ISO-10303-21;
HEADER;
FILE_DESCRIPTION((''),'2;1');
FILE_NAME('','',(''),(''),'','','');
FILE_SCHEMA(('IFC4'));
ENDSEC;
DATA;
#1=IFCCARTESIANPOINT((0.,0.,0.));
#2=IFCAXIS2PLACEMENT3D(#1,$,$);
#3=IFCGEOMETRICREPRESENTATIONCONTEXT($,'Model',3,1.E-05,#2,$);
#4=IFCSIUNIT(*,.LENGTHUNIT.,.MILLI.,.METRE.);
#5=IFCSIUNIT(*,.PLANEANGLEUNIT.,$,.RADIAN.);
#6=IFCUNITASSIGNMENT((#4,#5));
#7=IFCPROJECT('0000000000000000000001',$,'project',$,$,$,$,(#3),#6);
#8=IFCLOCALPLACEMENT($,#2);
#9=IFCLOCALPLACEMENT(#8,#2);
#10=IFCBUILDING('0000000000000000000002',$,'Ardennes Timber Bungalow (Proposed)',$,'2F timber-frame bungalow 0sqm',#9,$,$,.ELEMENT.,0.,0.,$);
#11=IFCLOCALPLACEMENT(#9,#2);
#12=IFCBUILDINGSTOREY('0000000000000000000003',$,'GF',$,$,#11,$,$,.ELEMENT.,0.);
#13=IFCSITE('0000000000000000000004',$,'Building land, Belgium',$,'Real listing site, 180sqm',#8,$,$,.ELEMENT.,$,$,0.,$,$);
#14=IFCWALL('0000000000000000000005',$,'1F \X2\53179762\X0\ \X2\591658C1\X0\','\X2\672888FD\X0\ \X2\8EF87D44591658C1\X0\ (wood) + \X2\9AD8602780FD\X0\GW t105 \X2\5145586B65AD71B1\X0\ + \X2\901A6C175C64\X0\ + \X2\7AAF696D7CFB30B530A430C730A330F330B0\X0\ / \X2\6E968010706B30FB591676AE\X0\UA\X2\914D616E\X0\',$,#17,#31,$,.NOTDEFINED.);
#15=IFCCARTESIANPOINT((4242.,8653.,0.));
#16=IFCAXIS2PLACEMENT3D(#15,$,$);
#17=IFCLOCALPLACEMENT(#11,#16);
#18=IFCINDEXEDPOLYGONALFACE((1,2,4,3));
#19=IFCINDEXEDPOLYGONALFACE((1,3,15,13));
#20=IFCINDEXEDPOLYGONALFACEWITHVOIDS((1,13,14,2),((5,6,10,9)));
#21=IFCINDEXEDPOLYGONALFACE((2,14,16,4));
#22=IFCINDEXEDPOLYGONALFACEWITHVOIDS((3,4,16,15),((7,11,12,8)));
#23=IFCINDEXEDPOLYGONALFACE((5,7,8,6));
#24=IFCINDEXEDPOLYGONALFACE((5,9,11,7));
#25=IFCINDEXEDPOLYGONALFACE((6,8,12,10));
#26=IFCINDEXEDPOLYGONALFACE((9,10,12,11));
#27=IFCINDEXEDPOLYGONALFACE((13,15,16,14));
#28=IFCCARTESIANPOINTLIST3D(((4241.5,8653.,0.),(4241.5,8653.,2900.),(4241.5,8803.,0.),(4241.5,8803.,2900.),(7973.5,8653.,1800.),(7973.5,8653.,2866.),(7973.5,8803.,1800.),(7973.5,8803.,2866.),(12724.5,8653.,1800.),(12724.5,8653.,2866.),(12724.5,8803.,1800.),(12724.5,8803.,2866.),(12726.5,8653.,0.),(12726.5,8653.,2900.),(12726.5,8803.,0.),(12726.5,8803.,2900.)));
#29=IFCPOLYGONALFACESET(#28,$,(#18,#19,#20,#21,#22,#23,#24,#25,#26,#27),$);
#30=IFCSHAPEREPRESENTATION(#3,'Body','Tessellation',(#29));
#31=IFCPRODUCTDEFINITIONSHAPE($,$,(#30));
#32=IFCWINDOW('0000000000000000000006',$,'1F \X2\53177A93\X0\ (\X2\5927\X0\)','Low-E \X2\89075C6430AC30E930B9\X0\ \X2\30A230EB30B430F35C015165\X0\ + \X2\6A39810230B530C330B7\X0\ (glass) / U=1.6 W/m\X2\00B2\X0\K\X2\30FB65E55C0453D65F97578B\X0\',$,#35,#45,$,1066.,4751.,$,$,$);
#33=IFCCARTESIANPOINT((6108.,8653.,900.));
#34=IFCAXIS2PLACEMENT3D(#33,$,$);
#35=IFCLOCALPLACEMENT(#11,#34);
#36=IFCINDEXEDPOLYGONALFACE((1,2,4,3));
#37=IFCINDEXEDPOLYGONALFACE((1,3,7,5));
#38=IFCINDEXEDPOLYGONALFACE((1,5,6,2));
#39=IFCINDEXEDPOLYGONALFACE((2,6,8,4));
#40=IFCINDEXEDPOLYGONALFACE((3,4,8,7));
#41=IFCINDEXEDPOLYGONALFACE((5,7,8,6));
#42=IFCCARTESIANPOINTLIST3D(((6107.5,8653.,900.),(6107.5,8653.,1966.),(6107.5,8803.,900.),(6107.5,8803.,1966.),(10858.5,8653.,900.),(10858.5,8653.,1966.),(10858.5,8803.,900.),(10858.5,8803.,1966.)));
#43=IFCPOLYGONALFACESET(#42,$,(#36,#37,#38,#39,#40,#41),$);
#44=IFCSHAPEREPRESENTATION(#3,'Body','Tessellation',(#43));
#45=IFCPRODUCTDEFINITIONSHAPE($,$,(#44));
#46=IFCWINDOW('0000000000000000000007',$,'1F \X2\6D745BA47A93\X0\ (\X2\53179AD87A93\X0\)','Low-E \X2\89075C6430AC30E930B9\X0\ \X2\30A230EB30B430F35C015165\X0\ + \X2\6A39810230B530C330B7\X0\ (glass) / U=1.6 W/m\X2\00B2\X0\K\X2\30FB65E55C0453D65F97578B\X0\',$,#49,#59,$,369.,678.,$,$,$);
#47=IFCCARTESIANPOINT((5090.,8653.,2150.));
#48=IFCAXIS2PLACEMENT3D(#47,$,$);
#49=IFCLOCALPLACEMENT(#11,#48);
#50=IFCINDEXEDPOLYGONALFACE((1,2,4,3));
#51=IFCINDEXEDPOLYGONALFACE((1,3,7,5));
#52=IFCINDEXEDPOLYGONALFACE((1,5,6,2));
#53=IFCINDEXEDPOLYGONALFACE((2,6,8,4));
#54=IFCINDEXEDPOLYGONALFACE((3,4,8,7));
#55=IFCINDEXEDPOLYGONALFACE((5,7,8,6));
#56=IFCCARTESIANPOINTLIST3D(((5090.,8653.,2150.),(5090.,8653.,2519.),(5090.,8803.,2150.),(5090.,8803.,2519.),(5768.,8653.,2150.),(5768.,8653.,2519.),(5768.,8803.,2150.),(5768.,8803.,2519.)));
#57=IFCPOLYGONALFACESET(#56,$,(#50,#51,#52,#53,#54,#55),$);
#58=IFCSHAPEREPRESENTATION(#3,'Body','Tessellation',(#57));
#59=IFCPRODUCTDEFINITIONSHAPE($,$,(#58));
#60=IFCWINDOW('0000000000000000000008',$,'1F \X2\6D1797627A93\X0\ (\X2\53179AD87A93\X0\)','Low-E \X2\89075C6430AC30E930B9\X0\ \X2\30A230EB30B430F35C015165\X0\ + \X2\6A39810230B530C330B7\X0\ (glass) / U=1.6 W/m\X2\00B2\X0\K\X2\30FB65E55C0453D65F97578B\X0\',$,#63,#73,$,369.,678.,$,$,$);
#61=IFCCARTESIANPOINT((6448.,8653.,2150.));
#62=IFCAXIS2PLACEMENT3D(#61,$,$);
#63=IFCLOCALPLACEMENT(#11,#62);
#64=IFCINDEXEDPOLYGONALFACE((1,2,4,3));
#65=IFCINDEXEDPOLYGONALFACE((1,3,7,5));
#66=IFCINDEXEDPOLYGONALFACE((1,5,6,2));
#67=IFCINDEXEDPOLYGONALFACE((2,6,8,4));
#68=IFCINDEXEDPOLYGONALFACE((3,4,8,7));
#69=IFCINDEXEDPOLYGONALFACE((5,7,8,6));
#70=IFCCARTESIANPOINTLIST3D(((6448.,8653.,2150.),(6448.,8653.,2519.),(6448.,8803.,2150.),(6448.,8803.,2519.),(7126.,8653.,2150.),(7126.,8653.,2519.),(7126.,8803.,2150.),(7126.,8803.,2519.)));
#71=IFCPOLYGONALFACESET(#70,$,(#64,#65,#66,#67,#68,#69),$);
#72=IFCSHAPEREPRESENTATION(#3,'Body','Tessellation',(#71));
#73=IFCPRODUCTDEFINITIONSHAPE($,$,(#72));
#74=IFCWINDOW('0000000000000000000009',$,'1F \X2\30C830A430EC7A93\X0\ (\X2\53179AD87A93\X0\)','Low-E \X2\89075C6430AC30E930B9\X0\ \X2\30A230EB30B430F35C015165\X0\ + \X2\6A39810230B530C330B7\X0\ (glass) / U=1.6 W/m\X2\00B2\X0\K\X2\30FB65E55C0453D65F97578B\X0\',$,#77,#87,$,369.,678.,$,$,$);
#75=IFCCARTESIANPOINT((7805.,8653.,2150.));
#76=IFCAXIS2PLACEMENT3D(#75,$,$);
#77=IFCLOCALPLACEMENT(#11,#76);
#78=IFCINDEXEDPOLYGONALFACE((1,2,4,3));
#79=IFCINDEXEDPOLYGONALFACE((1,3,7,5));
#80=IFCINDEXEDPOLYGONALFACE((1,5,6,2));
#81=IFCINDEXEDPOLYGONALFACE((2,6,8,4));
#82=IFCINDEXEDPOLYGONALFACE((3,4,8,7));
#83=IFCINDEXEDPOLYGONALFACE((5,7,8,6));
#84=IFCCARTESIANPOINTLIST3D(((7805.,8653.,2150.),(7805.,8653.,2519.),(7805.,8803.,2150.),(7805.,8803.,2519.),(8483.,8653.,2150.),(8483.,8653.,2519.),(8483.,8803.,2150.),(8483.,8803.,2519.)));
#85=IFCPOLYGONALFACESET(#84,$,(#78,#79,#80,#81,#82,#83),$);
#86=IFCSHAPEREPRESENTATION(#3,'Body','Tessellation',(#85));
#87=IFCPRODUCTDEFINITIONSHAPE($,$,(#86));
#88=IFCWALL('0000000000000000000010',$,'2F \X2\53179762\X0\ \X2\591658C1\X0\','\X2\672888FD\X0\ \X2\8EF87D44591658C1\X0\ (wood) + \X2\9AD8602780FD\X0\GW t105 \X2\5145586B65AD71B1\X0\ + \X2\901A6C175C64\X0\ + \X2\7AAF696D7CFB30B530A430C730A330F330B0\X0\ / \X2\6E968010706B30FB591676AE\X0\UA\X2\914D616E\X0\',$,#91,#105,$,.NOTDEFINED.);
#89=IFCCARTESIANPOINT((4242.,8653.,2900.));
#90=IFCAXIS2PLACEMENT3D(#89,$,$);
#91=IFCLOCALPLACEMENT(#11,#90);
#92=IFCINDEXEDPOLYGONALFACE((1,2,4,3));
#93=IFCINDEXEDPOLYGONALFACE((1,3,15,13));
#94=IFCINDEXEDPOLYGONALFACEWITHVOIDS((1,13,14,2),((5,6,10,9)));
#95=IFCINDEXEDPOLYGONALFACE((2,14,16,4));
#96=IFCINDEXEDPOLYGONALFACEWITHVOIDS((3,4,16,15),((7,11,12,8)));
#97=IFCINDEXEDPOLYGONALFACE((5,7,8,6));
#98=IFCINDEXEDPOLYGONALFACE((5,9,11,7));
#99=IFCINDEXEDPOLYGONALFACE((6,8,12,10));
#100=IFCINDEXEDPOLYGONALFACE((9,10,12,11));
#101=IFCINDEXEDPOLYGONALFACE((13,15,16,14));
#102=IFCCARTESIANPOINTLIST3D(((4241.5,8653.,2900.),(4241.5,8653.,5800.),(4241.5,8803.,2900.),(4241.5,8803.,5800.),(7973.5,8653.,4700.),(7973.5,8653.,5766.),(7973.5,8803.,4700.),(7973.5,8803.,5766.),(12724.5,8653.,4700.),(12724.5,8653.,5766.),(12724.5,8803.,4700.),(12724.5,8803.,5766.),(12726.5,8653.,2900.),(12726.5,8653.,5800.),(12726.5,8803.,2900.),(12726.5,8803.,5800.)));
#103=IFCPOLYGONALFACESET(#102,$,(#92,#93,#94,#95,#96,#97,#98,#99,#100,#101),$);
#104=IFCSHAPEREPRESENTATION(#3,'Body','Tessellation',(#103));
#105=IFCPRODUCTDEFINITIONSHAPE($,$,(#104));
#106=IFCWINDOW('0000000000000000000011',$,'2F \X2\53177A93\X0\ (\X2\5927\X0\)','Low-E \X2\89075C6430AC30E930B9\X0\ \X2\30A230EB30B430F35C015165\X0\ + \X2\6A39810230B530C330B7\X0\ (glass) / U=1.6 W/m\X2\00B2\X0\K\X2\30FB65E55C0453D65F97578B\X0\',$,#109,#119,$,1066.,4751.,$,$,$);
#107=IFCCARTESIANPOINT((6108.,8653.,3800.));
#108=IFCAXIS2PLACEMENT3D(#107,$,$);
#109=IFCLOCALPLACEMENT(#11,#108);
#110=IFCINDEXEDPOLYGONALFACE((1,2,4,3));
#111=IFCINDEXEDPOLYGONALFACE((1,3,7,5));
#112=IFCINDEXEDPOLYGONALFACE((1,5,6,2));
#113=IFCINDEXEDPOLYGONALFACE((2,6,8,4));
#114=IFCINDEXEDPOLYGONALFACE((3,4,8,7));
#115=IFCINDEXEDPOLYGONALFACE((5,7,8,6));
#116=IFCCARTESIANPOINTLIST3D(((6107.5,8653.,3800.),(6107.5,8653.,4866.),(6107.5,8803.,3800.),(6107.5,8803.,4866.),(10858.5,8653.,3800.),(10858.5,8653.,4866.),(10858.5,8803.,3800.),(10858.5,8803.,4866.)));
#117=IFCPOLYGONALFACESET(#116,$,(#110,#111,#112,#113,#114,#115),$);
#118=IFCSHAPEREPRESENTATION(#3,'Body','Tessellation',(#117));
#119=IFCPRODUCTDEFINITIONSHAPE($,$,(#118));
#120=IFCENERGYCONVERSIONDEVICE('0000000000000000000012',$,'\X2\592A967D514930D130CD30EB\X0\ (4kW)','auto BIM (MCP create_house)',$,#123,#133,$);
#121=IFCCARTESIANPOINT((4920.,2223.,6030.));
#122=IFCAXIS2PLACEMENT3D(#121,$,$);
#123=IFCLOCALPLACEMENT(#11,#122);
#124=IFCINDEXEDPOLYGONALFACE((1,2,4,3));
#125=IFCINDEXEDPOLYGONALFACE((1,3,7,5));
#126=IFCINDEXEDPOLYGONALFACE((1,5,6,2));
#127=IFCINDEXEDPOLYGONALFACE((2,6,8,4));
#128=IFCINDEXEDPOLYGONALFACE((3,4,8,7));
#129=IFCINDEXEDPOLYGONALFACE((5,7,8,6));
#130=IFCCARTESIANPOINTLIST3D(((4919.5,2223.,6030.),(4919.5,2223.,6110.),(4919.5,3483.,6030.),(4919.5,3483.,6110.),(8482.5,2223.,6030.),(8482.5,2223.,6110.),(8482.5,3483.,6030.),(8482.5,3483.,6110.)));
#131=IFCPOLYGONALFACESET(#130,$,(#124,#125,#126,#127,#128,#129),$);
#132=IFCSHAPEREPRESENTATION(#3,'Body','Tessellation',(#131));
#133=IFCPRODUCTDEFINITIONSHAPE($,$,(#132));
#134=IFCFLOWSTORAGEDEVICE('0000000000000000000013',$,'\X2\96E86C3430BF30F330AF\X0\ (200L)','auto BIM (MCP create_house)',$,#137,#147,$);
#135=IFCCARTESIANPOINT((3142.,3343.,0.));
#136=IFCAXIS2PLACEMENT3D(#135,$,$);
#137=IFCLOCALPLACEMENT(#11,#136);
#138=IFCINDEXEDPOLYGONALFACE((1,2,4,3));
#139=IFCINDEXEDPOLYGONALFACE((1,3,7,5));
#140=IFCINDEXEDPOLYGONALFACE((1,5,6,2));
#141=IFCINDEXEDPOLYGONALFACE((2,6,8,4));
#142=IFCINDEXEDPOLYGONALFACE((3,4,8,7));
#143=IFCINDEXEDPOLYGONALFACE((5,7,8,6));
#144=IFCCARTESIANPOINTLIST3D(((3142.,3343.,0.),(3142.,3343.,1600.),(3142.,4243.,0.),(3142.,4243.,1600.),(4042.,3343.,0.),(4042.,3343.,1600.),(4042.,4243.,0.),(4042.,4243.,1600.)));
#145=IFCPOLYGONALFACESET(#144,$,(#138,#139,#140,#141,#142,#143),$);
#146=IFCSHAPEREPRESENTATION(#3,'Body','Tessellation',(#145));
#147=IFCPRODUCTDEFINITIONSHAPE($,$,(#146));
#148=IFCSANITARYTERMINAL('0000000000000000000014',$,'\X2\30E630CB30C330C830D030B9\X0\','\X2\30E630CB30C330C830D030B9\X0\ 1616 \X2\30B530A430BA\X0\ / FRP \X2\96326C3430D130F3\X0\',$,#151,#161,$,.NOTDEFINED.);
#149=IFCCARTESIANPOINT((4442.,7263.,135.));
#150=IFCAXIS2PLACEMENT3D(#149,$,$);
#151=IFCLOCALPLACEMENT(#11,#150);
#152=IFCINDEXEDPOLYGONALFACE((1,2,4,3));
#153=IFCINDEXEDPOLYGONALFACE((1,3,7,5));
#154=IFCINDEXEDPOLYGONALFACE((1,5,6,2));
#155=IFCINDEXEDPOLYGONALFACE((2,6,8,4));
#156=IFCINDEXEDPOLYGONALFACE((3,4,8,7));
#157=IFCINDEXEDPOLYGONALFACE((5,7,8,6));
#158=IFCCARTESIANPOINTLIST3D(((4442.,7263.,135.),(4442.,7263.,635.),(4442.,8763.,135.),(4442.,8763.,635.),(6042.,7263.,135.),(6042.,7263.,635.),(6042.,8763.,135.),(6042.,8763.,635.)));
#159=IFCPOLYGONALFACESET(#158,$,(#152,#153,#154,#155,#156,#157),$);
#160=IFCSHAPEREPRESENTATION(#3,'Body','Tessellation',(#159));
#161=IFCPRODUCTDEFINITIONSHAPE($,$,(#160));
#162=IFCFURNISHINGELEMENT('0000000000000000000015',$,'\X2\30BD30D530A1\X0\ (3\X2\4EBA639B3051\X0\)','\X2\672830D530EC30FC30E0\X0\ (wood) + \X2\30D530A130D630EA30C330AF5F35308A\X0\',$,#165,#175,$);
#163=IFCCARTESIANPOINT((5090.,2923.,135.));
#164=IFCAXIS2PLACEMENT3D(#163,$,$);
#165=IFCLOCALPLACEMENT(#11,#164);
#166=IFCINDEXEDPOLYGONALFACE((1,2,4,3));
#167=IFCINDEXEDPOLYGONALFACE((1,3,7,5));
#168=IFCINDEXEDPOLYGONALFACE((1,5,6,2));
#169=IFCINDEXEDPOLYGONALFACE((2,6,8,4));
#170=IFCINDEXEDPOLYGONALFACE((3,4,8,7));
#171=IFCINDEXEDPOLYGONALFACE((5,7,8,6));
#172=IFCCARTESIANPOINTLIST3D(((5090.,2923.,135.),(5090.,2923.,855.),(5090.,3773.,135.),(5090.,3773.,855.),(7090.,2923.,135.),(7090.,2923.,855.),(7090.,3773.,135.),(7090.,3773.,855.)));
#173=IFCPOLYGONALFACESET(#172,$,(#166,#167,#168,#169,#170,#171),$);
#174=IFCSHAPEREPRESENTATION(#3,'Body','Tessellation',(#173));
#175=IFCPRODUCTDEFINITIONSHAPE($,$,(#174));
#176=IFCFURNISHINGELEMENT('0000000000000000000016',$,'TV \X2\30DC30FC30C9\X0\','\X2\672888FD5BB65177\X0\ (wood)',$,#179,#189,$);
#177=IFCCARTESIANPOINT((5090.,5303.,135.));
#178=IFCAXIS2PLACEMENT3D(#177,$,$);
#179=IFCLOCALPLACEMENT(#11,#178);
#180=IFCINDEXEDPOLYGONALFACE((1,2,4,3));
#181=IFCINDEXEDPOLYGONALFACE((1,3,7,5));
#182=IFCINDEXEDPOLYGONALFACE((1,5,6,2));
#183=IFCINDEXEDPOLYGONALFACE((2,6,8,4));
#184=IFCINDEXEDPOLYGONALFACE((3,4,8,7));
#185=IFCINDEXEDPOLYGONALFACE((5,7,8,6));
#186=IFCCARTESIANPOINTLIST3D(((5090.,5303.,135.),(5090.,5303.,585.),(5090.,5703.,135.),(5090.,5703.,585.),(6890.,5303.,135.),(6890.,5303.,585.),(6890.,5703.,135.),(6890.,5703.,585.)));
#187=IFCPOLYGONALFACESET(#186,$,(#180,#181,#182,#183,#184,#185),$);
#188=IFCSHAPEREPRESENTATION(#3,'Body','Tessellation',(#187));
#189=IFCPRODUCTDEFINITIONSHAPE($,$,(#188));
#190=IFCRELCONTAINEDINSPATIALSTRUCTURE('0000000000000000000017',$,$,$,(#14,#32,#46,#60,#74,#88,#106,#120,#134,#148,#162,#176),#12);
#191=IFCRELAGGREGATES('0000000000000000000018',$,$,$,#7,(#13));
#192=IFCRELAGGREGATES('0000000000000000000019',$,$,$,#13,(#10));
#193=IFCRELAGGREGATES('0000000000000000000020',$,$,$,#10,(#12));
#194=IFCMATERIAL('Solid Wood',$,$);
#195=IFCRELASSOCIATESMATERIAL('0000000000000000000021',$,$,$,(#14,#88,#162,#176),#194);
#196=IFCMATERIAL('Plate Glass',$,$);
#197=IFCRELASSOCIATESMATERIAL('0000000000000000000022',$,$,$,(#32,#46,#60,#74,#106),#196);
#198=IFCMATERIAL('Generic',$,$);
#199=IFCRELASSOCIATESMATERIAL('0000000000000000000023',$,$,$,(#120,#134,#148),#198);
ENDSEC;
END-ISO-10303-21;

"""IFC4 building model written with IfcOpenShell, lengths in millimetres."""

from ifc_helpers import new_model, si_unit, frame, frame_2d, origin, place, context, project, spatial, rectangle, extrude, material, element, fill, save


model = new_model("IFC4")

# Units and contexts
model_context = context("Model", 3, precision=1e-05, world=origin())
ifc_project = project(units=[si_unit("LENGTHUNIT", "METRE", prefix="MILLI"), si_unit("PLANEANGLEUNIT", "RADIAN")], contexts=[model_context])

# Site, building, storey
site_placement = place(None, origin())
site = spatial("IfcSite", under=ifc_project, at=site_placement, Name="Building land, Belgium", ObjectType="Real listing site, 180sqm", CompositionType="ELEMENT", RefElevation=0.0)
building_placement = place(site_placement, origin())
building = spatial("IfcBuilding", under=site, at=building_placement, Name="Ardennes Timber Bungalow (Proposed)", ObjectType="2F timber-frame bungalow 0sqm", CompositionType="ELEMENT", ElevationOfRefHeight=0.0, ElevationOfTerrain=0.0)
storey_placement = place(building_placement, origin())
storey = spatial("IfcBuildingStorey", under=building, at=storey_placement, Name="GF", CompositionType="ELEMENT", Elevation=0.0)

# Wall, openings, windows
ifc_material_1 = material(Name="Solid Wood")
wall_1_placement = place(storey_placement, frame((4242.0, 8653.0, 0.0)))
wall_1 = element("IfcWall", 1, at=wall_1_placement, inside=storey, material=ifc_material_1, Name="1F 北面 外壁", Description="木製 軸組外壁 (wood) + 高性能GW t105 充填断熱 + 通気層 + 窯業系サイディング / 準耐火・外皮UA配慮", PredefinedType="NOTDEFINED", context=model_context, shape_type="SweptSolid", body=[
    extrude(rectangle(XDim=8485.0, YDim=150.0, at=frame_2d((4242.0, 75.0))), frame((4242.0, 8653.0, 0.0)), (0.0, 0.0, 1.0), 2900.0),
])
opening_1_placement = place(storey_placement, frame((6108.0, 8653.0, 900.0)))
opening_1 = element("IfcOpeningElement", 2, at=opening_1_placement, cuts=wall_1, PredefinedType="NOTDEFINED", context=model_context, shape_type="SweptSolid", body=[
    extrude(rectangle(XDim=4751.0, YDim=150.0, at=frame_2d((2375.0, 75.0))), frame((6108.0, 8653.0, 900.0)), (0.0, 0.0, 1.0), 1066.0),
])
opening_2_placement = place(storey_placement, frame((5090.0, 8653.0, 2150.0)))
opening_2 = element("IfcOpeningElement", 3, at=opening_2_placement, cuts=wall_1, PredefinedType="NOTDEFINED", context=model_context, shape_type="SweptSolid", body=[
    extrude(rectangle(XDim=678.0, YDim=150.0, at=frame_2d((339.0, 75.0))), frame((5090.0, 8653.0, 2150.0)), (0.0, 0.0, 1.0), 369.0),
])
opening_3_placement = place(storey_placement, frame((6448.0, 8653.0, 2150.0)))
opening_3 = element("IfcOpeningElement", 4, at=opening_3_placement, cuts=wall_1, PredefinedType="NOTDEFINED", context=model_context, shape_type="SweptSolid", body=[
    extrude(rectangle(XDim=678.0, YDim=150.0, at=frame_2d((339.0, 75.0))), frame((6448.0, 8653.0, 2150.0)), (0.0, 0.0, 1.0), 369.0),
])
opening_4_placement = place(storey_placement, frame((7805.0, 8653.0, 2150.0)))
opening_4 = element("IfcOpeningElement", 5, at=opening_4_placement, cuts=wall_1, PredefinedType="NOTDEFINED", context=model_context, shape_type="SweptSolid", body=[
    extrude(rectangle(XDim=678.0, YDim=150.0, at=frame_2d((339.0, 75.0))), frame((7805.0, 8653.0, 2150.0)), (0.0, 0.0, 1.0), 369.0),
])
ifc_material_2 = material(Name="Plate Glass")
window_1_placement = place(storey_placement, frame((6108.0, 8653.0, 900.0)))
window_1 = element("IfcWindow", 6, at=window_1_placement, inside=storey, material=ifc_material_2, Name="1F 北窓 (大)", Description="Low-E 複層ガラス アルゴン封入 + 樹脂サッシ (glass) / U=1.6 W/m²K・日射取得型", OverallHeight=1066.0, OverallWidth=4751.0, context=model_context, shape_type="SweptSolid", body=[
    extrude(rectangle(XDim=4751.0, YDim=150.0, at=frame_2d((2375.0, 75.0))), frame((6108.0, 8653.0, 900.0)), (0.0, 0.0, 1.0), 1066.0),
])
fill(opening_1, window_1)
window_2_placement = place(storey_placement, frame((5090.0, 8653.0, 2150.0)))
window_2 = element("IfcWindow", 7, at=window_2_placement, inside=storey, material=ifc_material_2, Name="1F 浴室窓 (北高窓)", Description="Low-E 複層ガラス アルゴン封入 + 樹脂サッシ (glass) / U=1.6 W/m²K・日射取得型", OverallHeight=369.0, OverallWidth=678.0, context=model_context, shape_type="SweptSolid", body=[
    extrude(rectangle(XDim=678.0, YDim=150.0, at=frame_2d((339.0, 75.0))), frame((5090.0, 8653.0, 2150.0)), (0.0, 0.0, 1.0), 369.0),
])
fill(opening_2, window_2)
window_3_placement = place(storey_placement, frame((6448.0, 8653.0, 2150.0)))
window_3 = element("IfcWindow", 8, at=window_3_placement, inside=storey, material=ifc_material_2, Name="1F 洗面窓 (北高窓)", Description="Low-E 複層ガラス アルゴン封入 + 樹脂サッシ (glass) / U=1.6 W/m²K・日射取得型", OverallHeight=369.0, OverallWidth=678.0, context=model_context, shape_type="SweptSolid", body=[
    extrude(rectangle(XDim=678.0, YDim=150.0, at=frame_2d((339.0, 75.0))), frame((6448.0, 8653.0, 2150.0)), (0.0, 0.0, 1.0), 369.0),
])
fill(opening_3, window_3)
window_4_placement = place(storey_placement, frame((7805.0, 8653.0, 2150.0)))
window_4 = element("IfcWindow", 9, at=window_4_placement, inside=storey, material=ifc_material_2, Name="1F トイレ窓 (北高窓)", Description="Low-E 複層ガラス アルゴン封入 + 樹脂サッシ (glass) / U=1.6 W/m²K・日射取得型", OverallHeight=369.0, OverallWidth=678.0, context=model_context, shape_type="SweptSolid", body=[
    extrude(rectangle(XDim=678.0, YDim=150.0, at=frame_2d((339.0, 75.0))), frame((7805.0, 8653.0, 2150.0)), (0.0, 0.0, 1.0), 369.0),
])
fill(opening_4, window_4)

# Wall, opening, window
wall_2_placement = place(storey_placement, frame((4242.0, 8653.0, 2900.0)))
wall_2 = element("IfcWall", 10, at=wall_2_placement, inside=storey, material=ifc_material_1, Name="2F 北面 外壁", Description="木製 軸組外壁 (wood) + 高性能GW t105 充填断熱 + 通気層 + 窯業系サイディング / 準耐火・外皮UA配慮", PredefinedType="NOTDEFINED", context=model_context, shape_type="SweptSolid", body=[
    extrude(rectangle(XDim=8485.0, YDim=150.0, at=frame_2d((4242.0, 75.0))), frame((4242.0, 8653.0, 2900.0)), (0.0, 0.0, 1.0), 2900.0),
])
opening_5_placement = place(storey_placement, frame((6108.0, 8653.0, 3800.0)))
opening_5 = element("IfcOpeningElement", 11, at=opening_5_placement, cuts=wall_2, PredefinedType="NOTDEFINED", context=model_context, shape_type="SweptSolid", body=[
    extrude(rectangle(XDim=4751.0, YDim=150.0, at=frame_2d((2375.0, 75.0))), frame((6108.0, 8653.0, 3800.0)), (0.0, 0.0, 1.0), 1066.0),
])
window_5_placement = place(storey_placement, frame((6108.0, 8653.0, 3800.0)))
window_5 = element("IfcWindow", 12, at=window_5_placement, inside=storey, material=ifc_material_2, Name="2F 北窓 (大)", Description="Low-E 複層ガラス アルゴン封入 + 樹脂サッシ (glass) / U=1.6 W/m²K・日射取得型", OverallHeight=1066.0, OverallWidth=4751.0, context=model_context, shape_type="SweptSolid", body=[
    extrude(rectangle(XDim=4751.0, YDim=150.0, at=frame_2d((2375.0, 75.0))), frame((6108.0, 8653.0, 3800.0)), (0.0, 0.0, 1.0), 1066.0),
])
fill(opening_5, window_5)

# Energy conversion device
ifc_material_3 = material(Name="Generic")
energy_conversion_device_placement = place(storey_placement, frame((4920.0, 2223.0, 6030.0)))
element("IfcEnergyConversionDevice", 13, at=energy_conversion_device_placement, inside=storey, material=ifc_material_3, Name="太陽光パネル (4kW)", Description="auto BIM (MCP create_house)", context=model_context, shape_type="SweptSolid", body=[
    extrude(rectangle(XDim=3563.0, YDim=1260.0, at=frame_2d((1781.0, 630.0))), frame((4920.0, 2223.0, 6030.0)), (0.0, 0.0, 1.0), 80.0),
])

# Flow storage device
flow_storage_device_placement = place(storey_placement, frame((3142.0, 3343.0, 0.0)))
element("IfcFlowStorageDevice", 14, at=flow_storage_device_placement, inside=storey, material=ifc_material_3, Name="雨水タンク (200L)", Description="auto BIM (MCP create_house)", context=model_context, shape_type="SweptSolid", body=[
    extrude(rectangle(XDim=900.0, YDim=900.0, at=frame_2d((450.0, 450.0))), frame((3142.0, 3343.0, 0.0)), (0.0, 0.0, 1.0), 1600.0),
])

# Sanitary terminal
sanitary_terminal_placement = place(storey_placement, frame((4442.0, 7263.0, 135.0)))
element("IfcSanitaryTerminal", 15, at=sanitary_terminal_placement, inside=storey, material=ifc_material_3, Name="ユニットバス", Description="ユニットバス 1616 サイズ / FRP 防水パン", PredefinedType="NOTDEFINED", context=model_context, shape_type="SweptSolid", body=[
    extrude(rectangle(XDim=1600.0, YDim=1500.0, at=frame_2d((800.0, 750.0))), frame((4442.0, 7263.0, 135.0)), (0.0, 0.0, 1.0), 500.0),
])

# Furnishing elements
furnishing_1_placement = place(storey_placement, frame((5090.0, 2923.0, 135.0)))
element("IfcFurnishingElement", 16, at=furnishing_1_placement, inside=storey, material=ifc_material_1, Name="ソファ (3人掛け)", Description="木フレーム (wood) + ファブリック張り", context=model_context, shape_type="SweptSolid", body=[
    extrude(rectangle(XDim=2000.0, YDim=850.0, at=frame_2d((1000.0, 425.0))), frame((5090.0, 2923.0, 135.0)), (0.0, 0.0, 1.0), 720.0),
])
furnishing_2_placement = place(storey_placement, frame((5090.0, 5303.0, 135.0)))
element("IfcFurnishingElement", 17, at=furnishing_2_placement, inside=storey, material=ifc_material_1, Name="TV ボード", Description="木製家具 (wood)", context=model_context, shape_type="SweptSolid", body=[
    extrude(rectangle(XDim=1800.0, YDim=400.0, at=frame_2d((900.0, 200.0))), frame((5090.0, 5303.0, 135.0)), (0.0, 0.0, 1.0), 450.0),
])

save(model, "model.ifc")
